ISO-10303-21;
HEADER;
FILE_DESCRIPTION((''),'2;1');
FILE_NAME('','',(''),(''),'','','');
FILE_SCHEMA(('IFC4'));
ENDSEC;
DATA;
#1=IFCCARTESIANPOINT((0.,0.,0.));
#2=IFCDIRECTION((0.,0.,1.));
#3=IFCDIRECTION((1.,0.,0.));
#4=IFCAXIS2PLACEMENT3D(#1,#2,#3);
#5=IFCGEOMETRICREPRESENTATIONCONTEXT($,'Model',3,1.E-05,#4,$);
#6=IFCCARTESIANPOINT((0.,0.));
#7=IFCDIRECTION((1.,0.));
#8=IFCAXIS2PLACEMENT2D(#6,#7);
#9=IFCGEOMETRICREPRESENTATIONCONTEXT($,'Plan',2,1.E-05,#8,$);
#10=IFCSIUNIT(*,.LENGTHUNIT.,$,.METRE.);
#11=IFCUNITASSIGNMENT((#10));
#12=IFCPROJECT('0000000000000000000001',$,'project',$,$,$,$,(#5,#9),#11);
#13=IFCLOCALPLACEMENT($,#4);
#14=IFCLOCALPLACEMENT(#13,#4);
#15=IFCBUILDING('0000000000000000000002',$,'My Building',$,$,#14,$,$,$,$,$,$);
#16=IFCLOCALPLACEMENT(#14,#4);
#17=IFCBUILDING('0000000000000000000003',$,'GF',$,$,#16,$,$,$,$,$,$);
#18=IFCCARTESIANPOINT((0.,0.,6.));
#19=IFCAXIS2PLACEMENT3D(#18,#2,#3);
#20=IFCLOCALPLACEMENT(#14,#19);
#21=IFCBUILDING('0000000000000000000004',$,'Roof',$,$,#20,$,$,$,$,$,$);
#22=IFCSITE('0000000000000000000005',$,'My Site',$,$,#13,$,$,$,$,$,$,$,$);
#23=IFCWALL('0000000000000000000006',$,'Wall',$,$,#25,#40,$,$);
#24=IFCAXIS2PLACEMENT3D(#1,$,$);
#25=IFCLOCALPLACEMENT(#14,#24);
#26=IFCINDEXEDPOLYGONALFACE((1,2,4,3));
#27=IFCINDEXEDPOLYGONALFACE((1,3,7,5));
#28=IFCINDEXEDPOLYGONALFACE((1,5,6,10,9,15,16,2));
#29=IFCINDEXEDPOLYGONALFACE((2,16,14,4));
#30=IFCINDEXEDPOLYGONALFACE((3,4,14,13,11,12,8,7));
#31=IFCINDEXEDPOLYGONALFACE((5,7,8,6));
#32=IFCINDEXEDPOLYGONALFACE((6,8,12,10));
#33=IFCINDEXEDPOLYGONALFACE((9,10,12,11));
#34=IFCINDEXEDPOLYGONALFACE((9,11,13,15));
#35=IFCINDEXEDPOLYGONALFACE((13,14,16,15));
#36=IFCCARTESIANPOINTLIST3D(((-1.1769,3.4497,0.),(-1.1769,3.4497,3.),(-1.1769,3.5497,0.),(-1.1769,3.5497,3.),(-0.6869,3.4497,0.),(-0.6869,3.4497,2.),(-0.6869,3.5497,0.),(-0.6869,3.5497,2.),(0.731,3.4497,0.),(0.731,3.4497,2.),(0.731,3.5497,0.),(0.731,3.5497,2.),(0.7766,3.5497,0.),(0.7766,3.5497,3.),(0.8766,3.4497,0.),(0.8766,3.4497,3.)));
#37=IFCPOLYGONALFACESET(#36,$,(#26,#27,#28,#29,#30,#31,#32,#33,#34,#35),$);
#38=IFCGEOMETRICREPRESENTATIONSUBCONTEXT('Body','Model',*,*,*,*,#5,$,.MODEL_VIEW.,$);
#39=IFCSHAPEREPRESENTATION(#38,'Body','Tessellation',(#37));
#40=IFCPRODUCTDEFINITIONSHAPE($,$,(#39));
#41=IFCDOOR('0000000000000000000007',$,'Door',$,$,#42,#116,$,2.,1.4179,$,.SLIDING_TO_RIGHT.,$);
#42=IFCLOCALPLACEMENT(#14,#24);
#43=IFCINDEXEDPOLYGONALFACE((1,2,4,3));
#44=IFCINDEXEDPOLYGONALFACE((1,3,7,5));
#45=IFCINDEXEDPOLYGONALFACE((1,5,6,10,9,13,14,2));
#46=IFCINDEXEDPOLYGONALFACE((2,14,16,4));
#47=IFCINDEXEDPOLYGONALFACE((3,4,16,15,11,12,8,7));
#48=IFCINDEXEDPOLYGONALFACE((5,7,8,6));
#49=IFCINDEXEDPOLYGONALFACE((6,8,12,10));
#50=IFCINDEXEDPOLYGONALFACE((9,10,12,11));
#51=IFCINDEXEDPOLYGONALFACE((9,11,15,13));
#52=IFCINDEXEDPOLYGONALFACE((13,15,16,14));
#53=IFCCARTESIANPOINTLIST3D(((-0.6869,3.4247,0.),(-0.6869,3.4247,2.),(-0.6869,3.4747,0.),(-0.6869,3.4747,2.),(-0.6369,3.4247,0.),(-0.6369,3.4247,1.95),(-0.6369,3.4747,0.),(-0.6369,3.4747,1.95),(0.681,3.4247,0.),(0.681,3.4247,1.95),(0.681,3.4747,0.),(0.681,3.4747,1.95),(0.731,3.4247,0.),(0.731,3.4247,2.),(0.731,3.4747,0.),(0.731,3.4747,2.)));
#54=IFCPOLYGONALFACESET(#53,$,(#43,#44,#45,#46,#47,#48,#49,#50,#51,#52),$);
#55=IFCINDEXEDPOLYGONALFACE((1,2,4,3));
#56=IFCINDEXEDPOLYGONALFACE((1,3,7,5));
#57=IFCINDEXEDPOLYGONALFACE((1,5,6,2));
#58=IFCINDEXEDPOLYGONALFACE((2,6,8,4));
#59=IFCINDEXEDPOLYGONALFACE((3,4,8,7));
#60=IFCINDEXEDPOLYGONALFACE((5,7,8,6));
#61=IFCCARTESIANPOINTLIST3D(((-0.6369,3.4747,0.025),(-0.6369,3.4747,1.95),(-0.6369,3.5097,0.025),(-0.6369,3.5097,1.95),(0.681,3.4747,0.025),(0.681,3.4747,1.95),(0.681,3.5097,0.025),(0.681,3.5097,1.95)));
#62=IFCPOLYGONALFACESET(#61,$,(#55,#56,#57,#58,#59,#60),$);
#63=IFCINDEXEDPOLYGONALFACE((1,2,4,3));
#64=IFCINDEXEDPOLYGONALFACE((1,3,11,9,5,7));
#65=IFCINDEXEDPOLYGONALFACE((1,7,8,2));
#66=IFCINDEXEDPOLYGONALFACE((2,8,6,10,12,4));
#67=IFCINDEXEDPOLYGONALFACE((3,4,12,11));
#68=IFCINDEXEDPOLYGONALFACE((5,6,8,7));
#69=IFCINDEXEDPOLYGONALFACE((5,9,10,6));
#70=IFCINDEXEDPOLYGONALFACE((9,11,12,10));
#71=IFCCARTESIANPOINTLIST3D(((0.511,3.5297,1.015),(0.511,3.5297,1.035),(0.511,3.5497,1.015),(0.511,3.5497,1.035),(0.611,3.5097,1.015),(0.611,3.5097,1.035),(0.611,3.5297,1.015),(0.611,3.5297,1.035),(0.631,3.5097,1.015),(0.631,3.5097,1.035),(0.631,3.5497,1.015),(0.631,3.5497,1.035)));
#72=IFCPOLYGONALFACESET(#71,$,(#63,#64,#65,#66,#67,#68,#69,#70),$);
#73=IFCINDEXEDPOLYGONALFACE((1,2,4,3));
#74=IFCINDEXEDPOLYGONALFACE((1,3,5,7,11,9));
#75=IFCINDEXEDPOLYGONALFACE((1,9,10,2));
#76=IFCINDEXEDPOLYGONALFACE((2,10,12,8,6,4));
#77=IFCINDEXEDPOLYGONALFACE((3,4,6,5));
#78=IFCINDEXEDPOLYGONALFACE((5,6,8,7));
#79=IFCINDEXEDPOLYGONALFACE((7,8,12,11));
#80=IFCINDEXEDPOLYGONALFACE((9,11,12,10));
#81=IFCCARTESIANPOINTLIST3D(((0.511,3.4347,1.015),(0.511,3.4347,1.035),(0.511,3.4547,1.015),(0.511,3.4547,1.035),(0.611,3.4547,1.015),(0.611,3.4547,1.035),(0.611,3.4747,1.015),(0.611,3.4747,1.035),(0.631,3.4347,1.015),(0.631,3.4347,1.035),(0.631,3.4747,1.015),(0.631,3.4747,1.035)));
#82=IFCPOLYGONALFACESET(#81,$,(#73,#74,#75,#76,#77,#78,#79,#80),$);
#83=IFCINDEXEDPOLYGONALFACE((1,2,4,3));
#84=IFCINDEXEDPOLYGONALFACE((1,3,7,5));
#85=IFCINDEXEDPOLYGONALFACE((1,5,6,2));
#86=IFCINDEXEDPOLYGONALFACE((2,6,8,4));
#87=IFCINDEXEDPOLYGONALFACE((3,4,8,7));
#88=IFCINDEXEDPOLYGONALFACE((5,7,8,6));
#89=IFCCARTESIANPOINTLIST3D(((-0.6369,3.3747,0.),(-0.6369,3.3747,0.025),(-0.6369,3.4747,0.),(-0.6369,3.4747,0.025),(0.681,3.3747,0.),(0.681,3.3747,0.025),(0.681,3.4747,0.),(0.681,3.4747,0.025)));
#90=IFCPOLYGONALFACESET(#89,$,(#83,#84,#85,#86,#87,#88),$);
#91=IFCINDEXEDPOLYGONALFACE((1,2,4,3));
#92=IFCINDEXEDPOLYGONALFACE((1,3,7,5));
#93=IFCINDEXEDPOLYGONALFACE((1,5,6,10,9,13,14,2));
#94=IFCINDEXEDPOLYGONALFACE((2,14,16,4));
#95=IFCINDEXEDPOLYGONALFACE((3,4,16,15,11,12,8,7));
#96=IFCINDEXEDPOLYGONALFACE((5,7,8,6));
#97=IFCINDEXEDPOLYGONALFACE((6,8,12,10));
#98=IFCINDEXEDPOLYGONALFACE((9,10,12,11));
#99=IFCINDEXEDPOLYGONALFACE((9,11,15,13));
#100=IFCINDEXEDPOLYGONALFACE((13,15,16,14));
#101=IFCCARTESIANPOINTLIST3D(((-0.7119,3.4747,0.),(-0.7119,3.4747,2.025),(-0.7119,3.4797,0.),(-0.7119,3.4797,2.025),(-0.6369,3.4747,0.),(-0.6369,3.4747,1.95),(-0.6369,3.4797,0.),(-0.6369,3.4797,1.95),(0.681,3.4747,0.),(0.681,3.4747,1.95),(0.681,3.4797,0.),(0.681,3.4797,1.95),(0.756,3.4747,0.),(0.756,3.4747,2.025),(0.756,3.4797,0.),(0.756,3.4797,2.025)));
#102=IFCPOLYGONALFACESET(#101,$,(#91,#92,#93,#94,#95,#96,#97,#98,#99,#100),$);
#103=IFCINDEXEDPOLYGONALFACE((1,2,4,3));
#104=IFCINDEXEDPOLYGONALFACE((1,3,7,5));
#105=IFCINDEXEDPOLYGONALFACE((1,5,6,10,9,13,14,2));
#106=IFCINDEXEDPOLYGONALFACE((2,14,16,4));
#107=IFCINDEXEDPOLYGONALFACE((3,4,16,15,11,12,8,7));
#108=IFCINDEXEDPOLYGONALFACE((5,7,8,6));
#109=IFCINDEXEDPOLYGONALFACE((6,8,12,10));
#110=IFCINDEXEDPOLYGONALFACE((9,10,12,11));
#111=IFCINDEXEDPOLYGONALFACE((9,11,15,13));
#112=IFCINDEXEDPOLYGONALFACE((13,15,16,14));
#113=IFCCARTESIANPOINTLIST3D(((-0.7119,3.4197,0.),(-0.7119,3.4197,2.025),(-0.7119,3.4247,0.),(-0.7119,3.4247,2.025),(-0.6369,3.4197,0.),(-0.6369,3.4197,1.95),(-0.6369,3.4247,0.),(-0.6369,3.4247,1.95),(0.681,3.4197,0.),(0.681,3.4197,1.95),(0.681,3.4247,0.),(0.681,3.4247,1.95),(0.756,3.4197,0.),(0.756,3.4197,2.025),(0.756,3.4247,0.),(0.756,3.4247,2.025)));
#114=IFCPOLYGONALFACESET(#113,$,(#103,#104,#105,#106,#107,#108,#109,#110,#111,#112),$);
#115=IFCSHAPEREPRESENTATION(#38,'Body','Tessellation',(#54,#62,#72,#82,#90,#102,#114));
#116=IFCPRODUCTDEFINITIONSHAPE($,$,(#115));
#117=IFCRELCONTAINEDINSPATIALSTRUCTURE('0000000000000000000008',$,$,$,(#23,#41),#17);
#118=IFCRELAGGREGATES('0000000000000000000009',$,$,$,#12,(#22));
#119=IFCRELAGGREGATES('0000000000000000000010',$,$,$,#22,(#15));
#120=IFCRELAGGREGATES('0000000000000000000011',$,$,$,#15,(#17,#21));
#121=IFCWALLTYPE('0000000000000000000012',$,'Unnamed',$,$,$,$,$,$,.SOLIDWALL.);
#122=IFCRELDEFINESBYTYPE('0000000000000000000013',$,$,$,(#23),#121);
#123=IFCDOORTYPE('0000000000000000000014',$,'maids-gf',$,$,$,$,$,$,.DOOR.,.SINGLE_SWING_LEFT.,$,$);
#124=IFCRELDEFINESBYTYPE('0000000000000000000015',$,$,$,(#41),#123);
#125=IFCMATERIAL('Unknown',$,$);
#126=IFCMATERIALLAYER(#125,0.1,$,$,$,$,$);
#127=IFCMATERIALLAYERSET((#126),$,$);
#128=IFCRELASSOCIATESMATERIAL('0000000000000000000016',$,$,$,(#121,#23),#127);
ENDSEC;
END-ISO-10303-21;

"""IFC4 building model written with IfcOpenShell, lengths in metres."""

from ifc_helpers import new_model, entity, si_unit, frame, origin_with_axes, origin_2d_with_axis, place, context, subcontext, project, spatial, line, indexed_curve, outline, extrude, shape, source, transform, mapped, material, layer, layer_set, layer_usage, type_object, type_shapes, element, fill, save


model = new_model("IFC4")

# Units and contexts
model_context = context("Model", 3, precision=1e-05, world=origin_with_axes())
plan_context = context("Plan", 2, precision=1e-05, world=origin_2d_with_axis())
body_context_1 = subcontext(model_context, "Body", "Model", "MODEL_VIEW")
body_context_2 = subcontext(plan_context, "Body", "Plan", "PLAN_VIEW")
ifc_project = project(units=[si_unit("LENGTHUNIT", "METRE")], contexts=[model_context, plan_context])

# Site, buildings
site_placement = place(None, origin_with_axes())
site = spatial("IfcSite", under=ifc_project, at=site_placement, Name="My Site")
building_1_placement = place(site_placement, origin_with_axes())
building_1 = spatial("IfcBuilding", under=site, at=building_1_placement, Name="My Building")
building_2_placement = place(building_1_placement, origin_with_axes())
building_2 = spatial("IfcBuilding", under=building_1, at=building_2_placement, Name="GF")

# Shared definitions
ifc_material = material(Name="Unknown")

# Shared definitions
building_3_placement = place(building_1_placement, frame((0.0, 0.0, 6.0), z_axis=(0.0, 0.0, 1.0), x_axis=(1.0, 0.0, 0.0)))
building_3 = spatial("IfcBuilding", under=building_1, at=building_3_placement, Name="Roof")

# Shared definitions
ifc_layer_1 = layer(ifc_material, 0.1)
ifc_layer_set_1 = layer_set([ifc_layer_1])
wall_type = type_object("IfcWallType", Name="Unnamed", PredefinedType="SOLIDWALL", material=ifc_layer_set_1)

# Wall, opening, door
ifc_layer_usage_1 = layer_usage(ifc_layer_set_1, "AXIS2", "POSITIVE", 0.0)
wall_1_placement = place(building_2_placement, frame((0.8766, 3.5497, 0.0), z_axis=(0.0, 0.0, 1.0), x_axis=(-1.0, 0.0, 0.0)))
wall_1 = element("IfcWall", 1, at=wall_1_placement, inside=building_2, type_object=wall_type, material=ifc_layer_usage_1, Name="Wall", context=body_context_1, shape_type="SweptSolid", body=[
    extrude(outline(indexed_curve([(0.1, 0.0), (0.0, 0.1), (2.0535, 0.1), (2.0535, 0.0)], segments=[line(1, 2, 3, 4, 1)])), origin_with_axes(), (0.0, 0.0, 1.0), 3.0),
])
shared_shape_1 = source(origin_with_axes(), body_context_1, "Body", "SweptSolid", [
    extrude(outline(indexed_curve([(0.0, 0.0), (1.4179, 0.0), (1.4179, 2.0), (0.0, 2.0)], segments=[line(1, 2, 3, 4, 1)])), frame((0.0, -0.6, 0.0), z_axis=(0.0, -1.0, 0.0), x_axis=(1.0, 0.0, 0.0)), (0.0, 0.0, -1.0), 1.2),
])
opening_1_placement = place(wall_1_placement, frame((0.1456, 0.075, 0.0), z_axis=(0.0, 0.0, 1.0), x_axis=(1.0, -0.000001, 0.0)))
opening_1 = element("IfcOpeningElement", 2, at=opening_1_placement, cuts=wall_1, PredefinedType="OPENING", context=body_context_1, shape_type="MappedRepresentation", body=[
    mapped(shared_shape_1, transform((0.0, 0.0, 0.0), x_axis=(1.0, 0.0, 0.0), y_axis=(0.0, 1.0, 0.0), z_axis=(0.0, 0.0, 1.0), scale=1.0)),
])
door_type_1 = type_object("IfcDoorType", Name="maids-gf", OperationType="SINGLE_SWING_LEFT", PredefinedType="DOOR")
shared_shape_2 = source(origin_with_axes(), body_context_1, "Body", "SweptSolid", [
    extrude(outline(indexed_curve([(0.0, 0.0), (0.0, 2.0), (1.4179, 2.0), (1.4179, 0.0), (1.3679, 0.0), (1.3679, 1.95), (0.05, 1.95), (0.05, 0.0)], segments=[line(1, 2, 3, 4, 5, 6, 7, 8, 1)])), frame((0.0, 0.0, 0.0), z_axis=(0.0, -1.0, 0.0), x_axis=(1.0, 0.0, 0.0)), (0.0, 0.0, -1.0), 0.05),
    extrude(outline(indexed_curve([(0.0, 0.0), (1.3179, 0.0), (1.3179, 0.035), (0.0, 0.035)], segments=[line(1, 2, 3, 4, 1)])), frame((0.05, -0.035, 0.025), z_axis=(0.0, 0.0, 1.0), x_axis=(1.0, 0.0, 0.0)), (0.0, 0.0, 1.0), 1.925),
    extrude(outline(indexed_curve([(0.0, 0.0), (0.0, -0.04), (0.12, -0.04), (0.12, -0.02), (0.02, -0.02), (0.02, 0.0)], segments=[line(1, 2, 3, 4, 5, 6, 1)])), frame((0.1, -0.035, 1.015), z_axis=(0.0, 0.0, 1.0), x_axis=(1.0, 0.0, 0.0)), (0.0, 0.0, 1.0), 0.02),
    extrude(outline(indexed_curve([(0.0, 0.0), (0.0, 0.04), (0.12, 0.04), (0.12, 0.02), (0.02, 0.02), (0.02, 0.0)], segments=[line(1, 2, 3, 4, 5, 6, 1)])), frame((0.1, 0.0, 1.015), z_axis=(0.0, 0.0, 1.0), x_axis=(1.0, 0.0, 0.0)), (0.0, 0.0, 1.0), 0.02),
    extrude(outline(indexed_curve([(0.0, 0.0), (1.3179, 0.0), (1.3179, 0.1), (0.0, 0.1)], segments=[line(1, 2, 3, 4, 1)])), frame((0.05, 0.0, 0.0), z_axis=(0.0, 0.0, 1.0), x_axis=(1.0, 0.0, 0.0)), (0.0, 0.0, 1.0), 0.025),
    extrude(outline(indexed_curve([(0.0, 0.0), (0.0, 2.025), (1.4679, 2.025), (1.4679, 0.0), (1.3929, 0.0), (1.3929, 1.95), (0.075, 1.95), (0.075, 0.0)], segments=[line(1, 2, 3, 4, 5, 6, 7, 8, 1)])), frame((-0.025, -0.005, 0.0), z_axis=(0.0, -1.0, 0.0), x_axis=(1.0, 0.0, 0.0)), (0.0, 0.0, -1.0), 0.005),
    extrude(outline(indexed_curve([(0.0, 0.0), (0.0, 2.025), (1.4679, 2.025), (1.4679, 0.0), (1.3929, 0.0), (1.3929, 1.95), (0.075, 1.95), (0.075, 0.0)], segments=[line(1, 2, 3, 4, 5, 6, 7, 8, 1)])), frame((-0.025, 0.05, 0.0), z_axis=(0.0, -1.0, 0.0), x_axis=(1.0, 0.0, 0.0)), (0.0, 0.0, -1.0), 0.005),
])
shared_shape_3 = source(origin_with_axes(), body_context_2, "Body", "Curve2D", [
    entity("IfcIndexedPolyCurve", entity("IfcCartesianPointList2D", [[0.0, 0.0], [0.05, 0.0], [0.05, 0.05], [0.0, 0.05]]), [entity("IfcLineIndex", [1, 2, 3, 4, 1])]),
    entity("IfcIndexedPolyCurve", entity("IfcCartesianPointList2D", [[1.4179, 0.0], [1.3679, 0.0], [1.3679, 0.05], [1.4179, 0.05]]), [entity("IfcLineIndex", [1, 2, 3, 4, 1])]),
    entity("IfcIndexedPolyCurve", entity("IfcCartesianPointList2D", [[2.0269, -0.035], [0.709, -0.035], [0.709, 0.0], [2.0269, 0.0]]), [entity("IfcLineIndex", [1, 2, 3, 4, 1])]),
])
type_shapes(door_type_1, [shared_shape_2, shared_shape_3])
door_1_placement = place(opening_1_placement, frame((0.0, 0.0, 0.0), z_axis=(0.0, 0.0, 1.0), x_axis=(1.0, 0.0, 0.0)))
door_1 = element("IfcDoor", 3, at=door_1_placement, inside=building_2, type_object=door_type_1, Name="Door", OperationType="SLIDING_TO_RIGHT", OverallHeight=2.0, OverallWidth=1.4179, shapes=[
    shape(body_context_1, "Body", "MappedRepresentation", [mapped(shared_shape_2, transform((0.0, 0.0, 0.0), x_axis=(1.0, 0.0, 0.0), y_axis=(0.0, 1.0, 0.0), z_axis=(0.0, 0.0, 1.0), scale=1.0))]),
    shape(body_context_2, "Body", "MappedRepresentation", [mapped(shared_shape_3, transform((0.0, 0.0, 0.0), x_axis=(1.0, 0.0, 0.0), y_axis=(0.0, 1.0, 0.0), z_axis=(0.0, 0.0, 1.0), scale=1.0))]),
])
fill(opening_1, door_1)

save(model, "model.ifc")
